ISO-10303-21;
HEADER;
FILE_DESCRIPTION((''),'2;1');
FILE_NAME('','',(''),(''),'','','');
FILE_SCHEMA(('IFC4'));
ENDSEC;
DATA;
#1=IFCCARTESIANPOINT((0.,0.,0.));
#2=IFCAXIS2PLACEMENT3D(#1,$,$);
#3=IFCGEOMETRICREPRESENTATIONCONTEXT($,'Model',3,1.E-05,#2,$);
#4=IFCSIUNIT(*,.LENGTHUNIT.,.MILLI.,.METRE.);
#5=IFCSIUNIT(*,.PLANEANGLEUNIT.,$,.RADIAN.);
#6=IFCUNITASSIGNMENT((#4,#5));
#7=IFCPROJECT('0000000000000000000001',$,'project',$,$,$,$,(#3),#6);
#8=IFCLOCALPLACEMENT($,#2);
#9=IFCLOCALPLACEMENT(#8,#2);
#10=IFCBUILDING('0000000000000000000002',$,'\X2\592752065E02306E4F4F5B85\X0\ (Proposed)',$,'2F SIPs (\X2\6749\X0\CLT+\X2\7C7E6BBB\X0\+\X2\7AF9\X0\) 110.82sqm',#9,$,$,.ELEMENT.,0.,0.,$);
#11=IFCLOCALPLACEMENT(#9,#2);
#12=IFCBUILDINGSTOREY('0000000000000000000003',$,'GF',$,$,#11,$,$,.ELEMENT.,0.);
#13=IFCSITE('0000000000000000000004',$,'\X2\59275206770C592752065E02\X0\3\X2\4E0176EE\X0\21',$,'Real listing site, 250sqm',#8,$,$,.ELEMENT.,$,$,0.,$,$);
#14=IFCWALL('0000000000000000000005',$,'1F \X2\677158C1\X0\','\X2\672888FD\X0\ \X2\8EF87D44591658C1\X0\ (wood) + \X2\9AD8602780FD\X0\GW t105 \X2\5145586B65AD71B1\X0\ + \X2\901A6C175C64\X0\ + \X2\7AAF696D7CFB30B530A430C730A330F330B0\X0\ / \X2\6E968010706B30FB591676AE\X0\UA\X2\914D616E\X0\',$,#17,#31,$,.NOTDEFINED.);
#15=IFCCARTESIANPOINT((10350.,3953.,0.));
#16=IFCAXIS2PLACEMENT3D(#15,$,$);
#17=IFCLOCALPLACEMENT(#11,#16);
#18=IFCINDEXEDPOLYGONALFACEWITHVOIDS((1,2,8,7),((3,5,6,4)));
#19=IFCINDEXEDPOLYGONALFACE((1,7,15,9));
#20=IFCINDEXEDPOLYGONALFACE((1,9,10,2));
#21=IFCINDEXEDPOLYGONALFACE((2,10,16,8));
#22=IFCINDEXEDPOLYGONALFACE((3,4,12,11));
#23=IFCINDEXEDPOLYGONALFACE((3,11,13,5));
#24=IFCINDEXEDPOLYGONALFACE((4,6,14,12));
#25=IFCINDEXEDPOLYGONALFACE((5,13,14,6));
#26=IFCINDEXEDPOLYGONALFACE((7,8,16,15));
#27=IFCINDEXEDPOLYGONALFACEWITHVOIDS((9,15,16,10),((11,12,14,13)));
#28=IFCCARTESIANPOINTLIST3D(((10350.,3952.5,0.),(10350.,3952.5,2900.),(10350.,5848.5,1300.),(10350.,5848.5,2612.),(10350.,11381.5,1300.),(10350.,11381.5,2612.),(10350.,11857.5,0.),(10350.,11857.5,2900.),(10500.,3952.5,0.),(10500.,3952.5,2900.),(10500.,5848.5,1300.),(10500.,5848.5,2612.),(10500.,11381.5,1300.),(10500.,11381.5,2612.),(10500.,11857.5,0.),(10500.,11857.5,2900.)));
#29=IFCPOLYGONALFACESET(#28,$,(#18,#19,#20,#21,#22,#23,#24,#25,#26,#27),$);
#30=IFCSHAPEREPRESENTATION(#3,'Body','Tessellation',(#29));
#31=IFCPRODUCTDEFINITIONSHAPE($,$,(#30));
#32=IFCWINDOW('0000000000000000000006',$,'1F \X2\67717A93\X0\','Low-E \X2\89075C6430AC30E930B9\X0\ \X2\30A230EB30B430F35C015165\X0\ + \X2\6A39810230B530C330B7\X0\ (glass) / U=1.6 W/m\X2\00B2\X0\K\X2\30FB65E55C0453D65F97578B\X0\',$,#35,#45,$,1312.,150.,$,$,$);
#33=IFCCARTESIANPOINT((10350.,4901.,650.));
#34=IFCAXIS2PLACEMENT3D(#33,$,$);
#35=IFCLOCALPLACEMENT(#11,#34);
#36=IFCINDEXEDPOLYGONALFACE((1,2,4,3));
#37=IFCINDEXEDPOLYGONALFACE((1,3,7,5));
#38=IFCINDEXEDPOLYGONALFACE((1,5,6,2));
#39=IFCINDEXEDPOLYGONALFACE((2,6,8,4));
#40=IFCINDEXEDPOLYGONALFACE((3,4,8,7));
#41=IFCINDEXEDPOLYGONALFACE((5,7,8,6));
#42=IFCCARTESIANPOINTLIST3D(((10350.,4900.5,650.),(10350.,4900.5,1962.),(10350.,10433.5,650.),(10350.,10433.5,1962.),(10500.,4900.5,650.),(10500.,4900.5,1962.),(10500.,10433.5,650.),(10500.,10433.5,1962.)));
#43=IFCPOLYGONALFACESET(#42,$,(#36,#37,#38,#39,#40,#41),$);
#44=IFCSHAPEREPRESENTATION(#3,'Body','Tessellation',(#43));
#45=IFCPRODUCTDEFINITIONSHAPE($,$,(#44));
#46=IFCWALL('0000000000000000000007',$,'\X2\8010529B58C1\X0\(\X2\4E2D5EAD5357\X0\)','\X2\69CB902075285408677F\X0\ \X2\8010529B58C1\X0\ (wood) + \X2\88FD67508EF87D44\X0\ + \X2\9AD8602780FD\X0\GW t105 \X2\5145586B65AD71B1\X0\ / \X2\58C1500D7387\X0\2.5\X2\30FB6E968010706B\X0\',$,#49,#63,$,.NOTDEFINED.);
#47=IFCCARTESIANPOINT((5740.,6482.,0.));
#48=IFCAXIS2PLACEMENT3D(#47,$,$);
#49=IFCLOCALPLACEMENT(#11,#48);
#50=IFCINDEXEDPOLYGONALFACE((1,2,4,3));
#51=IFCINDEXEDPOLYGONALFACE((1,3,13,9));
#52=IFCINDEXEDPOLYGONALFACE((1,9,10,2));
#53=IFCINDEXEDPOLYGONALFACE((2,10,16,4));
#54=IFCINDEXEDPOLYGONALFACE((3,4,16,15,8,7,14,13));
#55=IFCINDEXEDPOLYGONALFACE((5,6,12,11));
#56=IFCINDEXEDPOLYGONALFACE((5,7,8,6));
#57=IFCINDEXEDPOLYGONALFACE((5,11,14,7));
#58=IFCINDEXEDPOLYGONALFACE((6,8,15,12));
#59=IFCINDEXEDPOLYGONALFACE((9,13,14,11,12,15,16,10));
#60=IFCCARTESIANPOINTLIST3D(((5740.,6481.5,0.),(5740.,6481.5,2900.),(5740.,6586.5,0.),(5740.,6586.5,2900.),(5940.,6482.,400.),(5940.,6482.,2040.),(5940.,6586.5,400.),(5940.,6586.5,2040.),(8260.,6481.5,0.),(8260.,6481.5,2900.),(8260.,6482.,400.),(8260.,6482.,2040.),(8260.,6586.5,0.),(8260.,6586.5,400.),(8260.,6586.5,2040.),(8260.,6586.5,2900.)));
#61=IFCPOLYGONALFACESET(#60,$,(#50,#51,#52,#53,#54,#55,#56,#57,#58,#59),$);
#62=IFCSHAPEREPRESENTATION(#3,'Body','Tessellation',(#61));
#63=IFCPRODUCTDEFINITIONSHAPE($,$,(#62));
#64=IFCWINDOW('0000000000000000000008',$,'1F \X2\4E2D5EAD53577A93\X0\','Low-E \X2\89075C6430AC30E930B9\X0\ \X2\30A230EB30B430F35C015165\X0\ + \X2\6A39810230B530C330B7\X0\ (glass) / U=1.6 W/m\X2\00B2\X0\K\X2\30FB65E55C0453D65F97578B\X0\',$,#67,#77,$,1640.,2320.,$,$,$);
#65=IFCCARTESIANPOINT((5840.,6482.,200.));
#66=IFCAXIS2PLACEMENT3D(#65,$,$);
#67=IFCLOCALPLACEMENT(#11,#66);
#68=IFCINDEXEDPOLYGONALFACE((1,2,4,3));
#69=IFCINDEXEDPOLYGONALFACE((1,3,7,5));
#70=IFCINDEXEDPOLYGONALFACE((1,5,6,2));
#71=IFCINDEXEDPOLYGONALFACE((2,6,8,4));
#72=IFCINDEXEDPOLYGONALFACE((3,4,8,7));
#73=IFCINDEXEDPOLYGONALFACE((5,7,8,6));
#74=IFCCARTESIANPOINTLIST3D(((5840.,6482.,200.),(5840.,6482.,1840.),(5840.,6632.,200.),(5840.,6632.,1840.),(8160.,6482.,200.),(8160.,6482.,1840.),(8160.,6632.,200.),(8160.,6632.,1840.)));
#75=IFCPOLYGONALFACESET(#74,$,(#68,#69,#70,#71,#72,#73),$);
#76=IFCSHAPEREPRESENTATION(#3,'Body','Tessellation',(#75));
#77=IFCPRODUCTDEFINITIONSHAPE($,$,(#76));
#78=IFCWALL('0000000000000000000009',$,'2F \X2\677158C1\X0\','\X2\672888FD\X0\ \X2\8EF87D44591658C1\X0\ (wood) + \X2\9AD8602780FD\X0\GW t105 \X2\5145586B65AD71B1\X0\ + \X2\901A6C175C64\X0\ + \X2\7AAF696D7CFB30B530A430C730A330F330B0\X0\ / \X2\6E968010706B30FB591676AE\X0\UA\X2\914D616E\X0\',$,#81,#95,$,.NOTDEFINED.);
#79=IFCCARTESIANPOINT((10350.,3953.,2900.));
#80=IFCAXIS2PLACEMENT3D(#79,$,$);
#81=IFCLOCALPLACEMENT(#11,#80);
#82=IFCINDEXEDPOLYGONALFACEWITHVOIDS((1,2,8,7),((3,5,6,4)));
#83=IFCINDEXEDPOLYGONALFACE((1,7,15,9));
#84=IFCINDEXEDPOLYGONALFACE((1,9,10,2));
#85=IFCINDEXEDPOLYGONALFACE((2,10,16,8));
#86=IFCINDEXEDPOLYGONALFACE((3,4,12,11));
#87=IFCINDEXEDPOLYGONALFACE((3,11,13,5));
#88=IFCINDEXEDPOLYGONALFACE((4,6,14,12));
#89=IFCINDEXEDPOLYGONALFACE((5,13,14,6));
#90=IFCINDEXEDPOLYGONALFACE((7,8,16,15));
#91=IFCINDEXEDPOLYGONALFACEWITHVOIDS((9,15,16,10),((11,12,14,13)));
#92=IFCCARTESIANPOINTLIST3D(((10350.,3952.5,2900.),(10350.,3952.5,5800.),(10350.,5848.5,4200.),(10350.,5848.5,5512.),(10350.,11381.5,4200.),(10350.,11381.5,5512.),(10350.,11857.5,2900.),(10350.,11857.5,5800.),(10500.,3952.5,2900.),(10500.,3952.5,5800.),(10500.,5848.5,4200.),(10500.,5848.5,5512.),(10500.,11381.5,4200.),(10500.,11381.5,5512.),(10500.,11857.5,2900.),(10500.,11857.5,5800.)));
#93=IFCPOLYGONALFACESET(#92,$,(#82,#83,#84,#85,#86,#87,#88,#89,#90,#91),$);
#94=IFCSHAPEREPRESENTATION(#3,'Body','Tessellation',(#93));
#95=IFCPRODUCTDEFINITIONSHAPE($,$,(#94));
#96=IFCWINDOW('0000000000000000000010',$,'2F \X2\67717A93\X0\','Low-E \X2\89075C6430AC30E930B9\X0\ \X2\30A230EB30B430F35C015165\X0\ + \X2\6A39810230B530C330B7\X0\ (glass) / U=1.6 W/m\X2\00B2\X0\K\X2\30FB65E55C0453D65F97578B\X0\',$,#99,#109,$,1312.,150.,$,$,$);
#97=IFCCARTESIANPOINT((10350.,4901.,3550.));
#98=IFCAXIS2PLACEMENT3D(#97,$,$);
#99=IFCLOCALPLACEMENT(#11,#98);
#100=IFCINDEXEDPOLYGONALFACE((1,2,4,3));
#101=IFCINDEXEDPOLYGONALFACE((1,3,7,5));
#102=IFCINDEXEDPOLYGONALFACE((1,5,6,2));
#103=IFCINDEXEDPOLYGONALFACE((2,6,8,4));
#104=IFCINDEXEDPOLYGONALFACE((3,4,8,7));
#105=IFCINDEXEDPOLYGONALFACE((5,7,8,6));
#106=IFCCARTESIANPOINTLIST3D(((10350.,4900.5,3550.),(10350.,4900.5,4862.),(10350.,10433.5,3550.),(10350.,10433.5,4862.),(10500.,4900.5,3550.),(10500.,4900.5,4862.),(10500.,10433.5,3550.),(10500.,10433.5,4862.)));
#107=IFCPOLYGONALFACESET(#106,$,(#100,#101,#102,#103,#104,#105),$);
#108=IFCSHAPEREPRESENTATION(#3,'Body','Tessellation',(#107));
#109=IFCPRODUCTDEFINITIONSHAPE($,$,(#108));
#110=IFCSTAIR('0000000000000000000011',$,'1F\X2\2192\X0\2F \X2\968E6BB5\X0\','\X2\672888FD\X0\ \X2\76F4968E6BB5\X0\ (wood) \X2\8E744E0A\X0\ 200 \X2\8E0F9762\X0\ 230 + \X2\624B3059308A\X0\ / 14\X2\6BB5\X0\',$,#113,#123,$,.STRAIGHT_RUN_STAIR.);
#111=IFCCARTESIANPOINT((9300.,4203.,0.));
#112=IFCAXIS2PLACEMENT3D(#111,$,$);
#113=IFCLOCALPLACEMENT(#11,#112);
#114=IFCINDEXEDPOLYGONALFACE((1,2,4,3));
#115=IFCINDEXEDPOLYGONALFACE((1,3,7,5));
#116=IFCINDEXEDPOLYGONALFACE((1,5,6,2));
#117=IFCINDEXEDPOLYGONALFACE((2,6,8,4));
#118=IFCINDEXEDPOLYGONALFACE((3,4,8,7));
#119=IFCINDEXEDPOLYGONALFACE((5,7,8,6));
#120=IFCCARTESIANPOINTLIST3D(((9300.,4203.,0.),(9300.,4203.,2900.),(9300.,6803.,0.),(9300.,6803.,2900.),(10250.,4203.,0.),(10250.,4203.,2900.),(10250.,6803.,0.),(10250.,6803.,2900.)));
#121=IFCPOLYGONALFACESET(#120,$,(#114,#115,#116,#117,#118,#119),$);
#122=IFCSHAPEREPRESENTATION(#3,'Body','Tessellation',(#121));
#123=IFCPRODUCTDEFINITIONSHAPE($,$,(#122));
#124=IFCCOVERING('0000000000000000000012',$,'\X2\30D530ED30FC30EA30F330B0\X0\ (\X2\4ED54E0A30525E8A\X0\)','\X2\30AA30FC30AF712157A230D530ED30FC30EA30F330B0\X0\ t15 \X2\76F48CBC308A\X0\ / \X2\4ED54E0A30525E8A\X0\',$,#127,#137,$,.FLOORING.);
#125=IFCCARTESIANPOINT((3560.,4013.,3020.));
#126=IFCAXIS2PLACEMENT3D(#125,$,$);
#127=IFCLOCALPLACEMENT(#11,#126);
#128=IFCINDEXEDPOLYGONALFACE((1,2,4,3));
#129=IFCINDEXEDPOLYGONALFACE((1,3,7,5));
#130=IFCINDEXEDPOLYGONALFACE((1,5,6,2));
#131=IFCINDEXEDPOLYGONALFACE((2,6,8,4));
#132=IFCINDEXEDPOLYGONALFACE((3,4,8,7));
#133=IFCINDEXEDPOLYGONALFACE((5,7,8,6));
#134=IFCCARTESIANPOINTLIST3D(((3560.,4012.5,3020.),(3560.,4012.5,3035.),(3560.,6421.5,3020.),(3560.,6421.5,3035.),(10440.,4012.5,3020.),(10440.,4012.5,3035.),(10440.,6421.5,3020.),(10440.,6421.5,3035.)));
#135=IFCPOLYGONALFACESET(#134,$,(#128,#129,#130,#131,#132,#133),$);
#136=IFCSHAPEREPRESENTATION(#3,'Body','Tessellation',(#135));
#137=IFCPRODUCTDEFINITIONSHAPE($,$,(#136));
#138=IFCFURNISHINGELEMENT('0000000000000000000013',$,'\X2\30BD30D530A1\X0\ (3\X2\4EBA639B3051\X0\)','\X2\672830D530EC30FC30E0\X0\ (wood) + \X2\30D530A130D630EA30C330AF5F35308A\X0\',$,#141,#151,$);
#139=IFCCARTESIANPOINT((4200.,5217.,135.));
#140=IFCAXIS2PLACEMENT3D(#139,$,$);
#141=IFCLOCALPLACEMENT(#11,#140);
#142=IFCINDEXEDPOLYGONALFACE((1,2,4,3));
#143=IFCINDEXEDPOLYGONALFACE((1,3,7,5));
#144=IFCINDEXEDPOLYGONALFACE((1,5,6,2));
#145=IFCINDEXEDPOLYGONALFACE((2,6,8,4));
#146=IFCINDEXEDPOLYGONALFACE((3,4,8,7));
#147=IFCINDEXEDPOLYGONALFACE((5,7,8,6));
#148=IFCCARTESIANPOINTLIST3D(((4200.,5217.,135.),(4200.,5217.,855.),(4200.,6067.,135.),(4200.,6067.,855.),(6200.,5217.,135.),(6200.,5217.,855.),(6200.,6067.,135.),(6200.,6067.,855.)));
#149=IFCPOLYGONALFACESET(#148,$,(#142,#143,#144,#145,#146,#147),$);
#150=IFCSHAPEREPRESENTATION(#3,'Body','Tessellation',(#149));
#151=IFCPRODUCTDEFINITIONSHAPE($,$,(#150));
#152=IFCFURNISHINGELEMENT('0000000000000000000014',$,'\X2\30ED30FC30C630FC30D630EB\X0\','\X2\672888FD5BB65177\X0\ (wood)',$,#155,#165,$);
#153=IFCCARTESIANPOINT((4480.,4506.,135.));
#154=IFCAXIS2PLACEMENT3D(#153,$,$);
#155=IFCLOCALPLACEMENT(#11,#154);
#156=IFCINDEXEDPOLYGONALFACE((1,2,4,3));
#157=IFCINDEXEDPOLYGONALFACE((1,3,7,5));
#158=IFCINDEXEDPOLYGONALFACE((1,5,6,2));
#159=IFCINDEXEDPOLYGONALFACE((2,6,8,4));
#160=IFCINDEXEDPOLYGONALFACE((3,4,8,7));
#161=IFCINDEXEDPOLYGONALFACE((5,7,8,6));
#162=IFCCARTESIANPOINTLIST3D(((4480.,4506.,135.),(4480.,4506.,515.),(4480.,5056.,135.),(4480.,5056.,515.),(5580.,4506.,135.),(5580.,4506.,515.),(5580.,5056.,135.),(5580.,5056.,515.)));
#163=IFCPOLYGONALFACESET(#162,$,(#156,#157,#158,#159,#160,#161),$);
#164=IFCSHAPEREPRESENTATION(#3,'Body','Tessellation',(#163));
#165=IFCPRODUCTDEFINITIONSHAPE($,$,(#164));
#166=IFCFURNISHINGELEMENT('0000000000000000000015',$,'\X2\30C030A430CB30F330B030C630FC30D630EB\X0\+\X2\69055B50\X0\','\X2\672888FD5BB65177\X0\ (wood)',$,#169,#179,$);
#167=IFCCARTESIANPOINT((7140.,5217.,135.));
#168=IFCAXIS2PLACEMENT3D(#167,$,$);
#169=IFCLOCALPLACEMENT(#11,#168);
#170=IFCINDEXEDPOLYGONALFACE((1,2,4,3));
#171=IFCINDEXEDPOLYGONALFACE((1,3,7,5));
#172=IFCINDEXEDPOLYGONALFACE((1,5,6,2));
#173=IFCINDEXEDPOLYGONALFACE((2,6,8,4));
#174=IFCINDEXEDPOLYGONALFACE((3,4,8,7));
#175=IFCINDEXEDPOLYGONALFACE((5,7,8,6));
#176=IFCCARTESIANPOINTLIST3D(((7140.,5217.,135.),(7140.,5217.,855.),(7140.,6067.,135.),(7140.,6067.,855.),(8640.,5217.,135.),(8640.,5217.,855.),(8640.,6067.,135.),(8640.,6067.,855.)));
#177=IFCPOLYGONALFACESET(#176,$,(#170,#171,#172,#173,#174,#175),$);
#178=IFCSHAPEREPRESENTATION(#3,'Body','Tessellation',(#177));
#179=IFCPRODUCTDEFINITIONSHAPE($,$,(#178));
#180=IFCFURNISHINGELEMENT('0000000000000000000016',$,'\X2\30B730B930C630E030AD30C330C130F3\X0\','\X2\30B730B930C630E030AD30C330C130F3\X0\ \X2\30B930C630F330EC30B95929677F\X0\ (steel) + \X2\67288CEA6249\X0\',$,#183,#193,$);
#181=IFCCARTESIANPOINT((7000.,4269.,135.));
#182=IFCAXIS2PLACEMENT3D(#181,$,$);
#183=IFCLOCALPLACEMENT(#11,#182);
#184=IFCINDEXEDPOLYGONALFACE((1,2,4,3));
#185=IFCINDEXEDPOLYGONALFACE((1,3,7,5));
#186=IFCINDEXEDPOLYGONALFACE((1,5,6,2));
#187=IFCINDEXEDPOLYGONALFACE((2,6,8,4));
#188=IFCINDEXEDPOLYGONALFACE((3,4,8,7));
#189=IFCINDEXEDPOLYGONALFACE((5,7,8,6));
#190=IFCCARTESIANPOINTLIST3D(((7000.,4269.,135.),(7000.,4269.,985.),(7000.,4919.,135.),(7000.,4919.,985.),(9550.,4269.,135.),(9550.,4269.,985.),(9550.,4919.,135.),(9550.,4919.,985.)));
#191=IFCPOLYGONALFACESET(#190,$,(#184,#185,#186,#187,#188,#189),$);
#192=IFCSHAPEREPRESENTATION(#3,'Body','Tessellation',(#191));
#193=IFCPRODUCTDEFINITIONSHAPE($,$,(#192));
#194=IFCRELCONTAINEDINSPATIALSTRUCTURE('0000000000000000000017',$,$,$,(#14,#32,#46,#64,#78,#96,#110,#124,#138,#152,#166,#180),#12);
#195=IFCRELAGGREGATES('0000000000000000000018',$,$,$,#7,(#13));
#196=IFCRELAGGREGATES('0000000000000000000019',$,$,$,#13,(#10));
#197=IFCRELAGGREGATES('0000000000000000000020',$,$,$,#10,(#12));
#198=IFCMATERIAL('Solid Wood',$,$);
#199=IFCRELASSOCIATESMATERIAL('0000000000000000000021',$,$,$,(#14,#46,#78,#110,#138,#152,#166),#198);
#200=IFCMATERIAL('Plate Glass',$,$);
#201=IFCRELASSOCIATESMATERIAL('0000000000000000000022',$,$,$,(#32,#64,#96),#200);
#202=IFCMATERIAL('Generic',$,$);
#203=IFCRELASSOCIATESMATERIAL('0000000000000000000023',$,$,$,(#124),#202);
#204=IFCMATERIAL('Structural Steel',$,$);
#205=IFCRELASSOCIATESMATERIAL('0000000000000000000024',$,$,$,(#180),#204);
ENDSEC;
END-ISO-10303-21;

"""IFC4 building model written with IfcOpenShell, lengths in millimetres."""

from ifc_helpers import new_model, si_unit, frame, frame_2d, origin, place, context, project, spatial, rectangle, extrude, material, element, fill, save


model = new_model("IFC4")

# Units and contexts
model_context = context("Model", 3, precision=1e-05, world=origin())
ifc_project = project(units=[si_unit("LENGTHUNIT", "METRE", prefix="MILLI"), si_unit("PLANEANGLEUNIT", "RADIAN")], contexts=[model_context])

# Site, building, storey
site_placement = place(None, origin())
site = spatial("IfcSite", under=ifc_project, at=site_placement, Name="大分県大分市3丁目21", ObjectType="Real listing site, 250sqm", CompositionType="ELEMENT", RefElevation=0.0)
building_placement = place(site_placement, origin())
building = spatial("IfcBuilding", under=site, at=building_placement, Name="大分市の住宅 (Proposed)", ObjectType="2F SIPs (杉CLT+籾殻+竹) 110.82sqm", CompositionType="ELEMENT", ElevationOfRefHeight=0.0, ElevationOfTerrain=0.0)
storey_placement = place(building_placement, origin())
storey = spatial("IfcBuildingStorey", under=building, at=storey_placement, Name="GF", CompositionType="ELEMENT", Elevation=0.0)

# Shared definitions
ifc_material_1 = material(Name="Solid Wood")

# Walls, openings, windows
wall_1_placement = place(storey_placement, frame((10350.0, 3953.0, 0.0)))
wall_1 = element("IfcWall", 1, at=wall_1_placement, inside=storey, material=ifc_material_1, Name="1F 東壁", Description="木製 軸組外壁 (wood) + 高性能GW t105 充填断熱 + 通気層 + 窯業系サイディング / 準耐火・外皮UA配慮", PredefinedType="NOTDEFINED", context=model_context, shape_type="SweptSolid", body=[
    extrude(rectangle(XDim=150.0, YDim=7905.0, at=frame_2d((75.0, 3952.0))), frame((10350.0, 3953.0, 0.0)), (0.0, 0.0, 1.0), 2900.0),
])
opening_1_placement = place(storey_placement, frame((10350.0, 4901.0, 650.0)))
opening_1 = element("IfcOpeningElement", 2, at=opening_1_placement, cuts=wall_1, PredefinedType="NOTDEFINED", context=model_context, shape_type="SweptSolid", body=[
    extrude(rectangle(XDim=150.0, YDim=5533.0, at=frame_2d((75.0, 2766.0))), frame((10350.0, 4901.0, 650.0)), (0.0, 0.0, 1.0), 1312.0),
])
ifc_material_2 = material(Name="Plate Glass")
window_1_placement = place(storey_placement, frame((10350.0, 4901.0, 650.0)))
window_1 = element("IfcWindow", 3, at=window_1_placement, inside=storey, material=ifc_material_2, Name="1F 東窓", Description="Low-E 複層ガラス アルゴン封入 + 樹脂サッシ (glass) / U=1.6 W/m²K・日射取得型", OverallHeight=1312.0, OverallWidth=150.0, context=model_context, shape_type="SweptSolid", body=[
    extrude(rectangle(XDim=150.0, YDim=5533.0, at=frame_2d((75.0, 2766.0))), frame((10350.0, 4901.0, 650.0)), (0.0, 0.0, 1.0), 1312.0),
])
fill(opening_1, window_1)
wall_2_placement = place(storey_placement, frame((5740.0, 6482.0, 0.0)))
wall_2 = element("IfcWall", 4, at=wall_2_placement, inside=storey, material=ifc_material_1, Name="耐力壁(中庭南)", Description="構造用合板 耐力壁 (wood) + 製材軸組 + 高性能GW t105 充填断熱 / 壁倍率2.5・準耐火", PredefinedType="NOTDEFINED", context=model_context, shape_type="SweptSolid", body=[
    extrude(rectangle(XDim=2520.0, YDim=105.0, at=frame_2d((1260.0, 52.0))), frame((5740.0, 6482.0, 0.0)), (0.0, 0.0, 1.0), 2900.0),
])
opening_2_placement = place(storey_placement, frame((5840.0, 6482.0, 200.0)))
opening_2 = element("IfcOpeningElement", 5, at=opening_2_placement, cuts=wall_2, PredefinedType="NOTDEFINED", context=model_context, shape_type="SweptSolid", body=[
    extrude(rectangle(XDim=2320.0, YDim=150.0, at=frame_2d((1160.0, 75.0))), frame((5840.0, 6482.0, 200.0)), (0.0, 0.0, 1.0), 1640.0),
])
window_2_placement = place(storey_placement, frame((5840.0, 6482.0, 200.0)))
window_2 = element("IfcWindow", 6, at=window_2_placement, inside=storey, material=ifc_material_2, Name="1F 中庭南窓", Description="Low-E 複層ガラス アルゴン封入 + 樹脂サッシ (glass) / U=1.6 W/m²K・日射取得型", OverallHeight=1640.0, OverallWidth=2320.0, context=model_context, shape_type="SweptSolid", body=[
    extrude(rectangle(XDim=2320.0, YDim=150.0, at=frame_2d((1160.0, 75.0))), frame((5840.0, 6482.0, 200.0)), (0.0, 0.0, 1.0), 1640.0),
])
fill(opening_2, window_2)

# Wall, opening, window
wall_3_placement = place(storey_placement, frame((10350.0, 3953.0, 2900.0)))
wall_3 = element("IfcWall", 7, at=wall_3_placement, inside=storey, material=ifc_material_1, Name="2F 東壁", Description="木製 軸組外壁 (wood) + 高性能GW t105 充填断熱 + 通気層 + 窯業系サイディング / 準耐火・外皮UA配慮", PredefinedType="NOTDEFINED", context=model_context, shape_type="SweptSolid", body=[
    extrude(rectangle(XDim=150.0, YDim=7905.0, at=frame_2d((75.0, 3952.0))), frame((10350.0, 3953.0, 2900.0)), (0.0, 0.0, 1.0), 2900.0),
])
opening_3_placement = place(storey_placement, frame((10350.0, 4901.0, 3550.0)))
opening_3 = element("IfcOpeningElement", 8, at=opening_3_placement, cuts=wall_3, PredefinedType="NOTDEFINED", context=model_context, shape_type="SweptSolid", body=[
    extrude(rectangle(XDim=150.0, YDim=5533.0, at=frame_2d((75.0, 2766.0))), frame((10350.0, 4901.0, 3550.0)), (0.0, 0.0, 1.0), 1312.0),
])
window_3_placement = place(storey_placement, frame((10350.0, 4901.0, 3550.0)))
window_3 = element("IfcWindow", 9, at=window_3_placement, inside=storey, material=ifc_material_2, Name="2F 東窓", Description="Low-E 複層ガラス アルゴン封入 + 樹脂サッシ (glass) / U=1.6 W/m²K・日射取得型", OverallHeight=1312.0, OverallWidth=150.0, context=model_context, shape_type="SweptSolid", body=[
    extrude(rectangle(XDim=150.0, YDim=5533.0, at=frame_2d((75.0, 2766.0))), frame((10350.0, 4901.0, 3550.0)), (0.0, 0.0, 1.0), 1312.0),
])
fill(opening_3, window_3)

# Stair
stair_placement = place(storey_placement, frame((9300.0, 4203.0, 0.0)))
element("IfcStair", 10, at=stair_placement, inside=storey, material=ifc_material_1, Name="1F→2F 階段", Description="木製 直階段 (wood) 蹴上 200 踏面 230 + 手すり / 14段", PredefinedType="STRAIGHT_RUN_STAIR", context=model_context, shape_type="SweptSolid", body=[
    extrude(rectangle(XDim=950.0, YDim=2600.0, at=frame_2d((475.0, 1300.0))), frame((9300.0, 4203.0, 0.0)), (0.0, 0.0, 1.0), 2900.0),
])

# Covering
ifc_material_3 = material(Name="Generic")
covering_placement = place(storey_placement, frame((3560.0, 4013.0, 3020.0)))
element("IfcCovering", 11, at=covering_placement, inside=storey, material=ifc_material_3, Name="フローリング (仕上げ床)", Description="オーク無垢フローリング t15 直貼り / 仕上げ床", PredefinedType="FLOORING", context=model_context, shape_type="SweptSolid", body=[
    extrude(rectangle(XDim=6880.0, YDim=2409.0, at=frame_2d((3440.0, 1204.0))), frame((3560.0, 4013.0, 3020.0)), (0.0, 0.0, 1.0), 15.0),
])

# Furnishing elements
furnishing_1_placement = place(storey_placement, frame((4200.0, 5217.0, 135.0)))
element("IfcFurnishingElement", 12, at=furnishing_1_placement, inside=storey, material=ifc_material_1, Name="ソファ (3人掛け)", Description="木フレーム (wood) + ファブリック張り", context=model_context, shape_type="SweptSolid", body=[
    extrude(rectangle(XDim=2000.0, YDim=850.0, at=frame_2d((1000.0, 425.0))), frame((4200.0, 5217.0, 135.0)), (0.0, 0.0, 1.0), 720.0),
])
furnishing_2_placement = place(storey_placement, frame((4480.0, 4506.0, 135.0)))
element("IfcFurnishingElement", 13, at=furnishing_2_placement, inside=storey, material=ifc_material_1, Name="ローテーブル", Description="木製家具 (wood)", context=model_context, shape_type="SweptSolid", body=[
    extrude(rectangle(XDim=1100.0, YDim=550.0, at=frame_2d((550.0, 275.0))), frame((4480.0, 4506.0, 135.0)), (0.0, 0.0, 1.0), 380.0),
])
furnishing_3_placement = place(storey_placement, frame((7140.0, 5217.0, 135.0)))
element("IfcFurnishingElement", 14, at=furnishing_3_placement, inside=storey, material=ifc_material_1, Name="ダイニングテーブル+椅子", Description="木製家具 (wood)", context=model_context, shape_type="SweptSolid", body=[
    extrude(rectangle(XDim=1500.0, YDim=850.0, at=frame_2d((750.0, 425.0))), frame((7140.0, 5217.0, 135.0)), (0.0, 0.0, 1.0), 720.0),
])
ifc_material_4 = material(Name="Structural Steel")
furnishing_4_placement = place(storey_placement, frame((7000.0, 4269.0, 135.0)))
element("IfcFurnishingElement", 15, at=furnishing_4_placement, inside=storey, material=ifc_material_4, Name="システムキッチン", Description="システムキッチン ステンレス天板 (steel) + 木質扉", context=model_context, shape_type="SweptSolid", body=[
    extrude(rectangle(XDim=2550.0, YDim=650.0, at=frame_2d((1275.0, 325.0))), frame((7000.0, 4269.0, 135.0)), (0.0, 0.0, 1.0), 850.0),
])

save(model, "model.ifc")
